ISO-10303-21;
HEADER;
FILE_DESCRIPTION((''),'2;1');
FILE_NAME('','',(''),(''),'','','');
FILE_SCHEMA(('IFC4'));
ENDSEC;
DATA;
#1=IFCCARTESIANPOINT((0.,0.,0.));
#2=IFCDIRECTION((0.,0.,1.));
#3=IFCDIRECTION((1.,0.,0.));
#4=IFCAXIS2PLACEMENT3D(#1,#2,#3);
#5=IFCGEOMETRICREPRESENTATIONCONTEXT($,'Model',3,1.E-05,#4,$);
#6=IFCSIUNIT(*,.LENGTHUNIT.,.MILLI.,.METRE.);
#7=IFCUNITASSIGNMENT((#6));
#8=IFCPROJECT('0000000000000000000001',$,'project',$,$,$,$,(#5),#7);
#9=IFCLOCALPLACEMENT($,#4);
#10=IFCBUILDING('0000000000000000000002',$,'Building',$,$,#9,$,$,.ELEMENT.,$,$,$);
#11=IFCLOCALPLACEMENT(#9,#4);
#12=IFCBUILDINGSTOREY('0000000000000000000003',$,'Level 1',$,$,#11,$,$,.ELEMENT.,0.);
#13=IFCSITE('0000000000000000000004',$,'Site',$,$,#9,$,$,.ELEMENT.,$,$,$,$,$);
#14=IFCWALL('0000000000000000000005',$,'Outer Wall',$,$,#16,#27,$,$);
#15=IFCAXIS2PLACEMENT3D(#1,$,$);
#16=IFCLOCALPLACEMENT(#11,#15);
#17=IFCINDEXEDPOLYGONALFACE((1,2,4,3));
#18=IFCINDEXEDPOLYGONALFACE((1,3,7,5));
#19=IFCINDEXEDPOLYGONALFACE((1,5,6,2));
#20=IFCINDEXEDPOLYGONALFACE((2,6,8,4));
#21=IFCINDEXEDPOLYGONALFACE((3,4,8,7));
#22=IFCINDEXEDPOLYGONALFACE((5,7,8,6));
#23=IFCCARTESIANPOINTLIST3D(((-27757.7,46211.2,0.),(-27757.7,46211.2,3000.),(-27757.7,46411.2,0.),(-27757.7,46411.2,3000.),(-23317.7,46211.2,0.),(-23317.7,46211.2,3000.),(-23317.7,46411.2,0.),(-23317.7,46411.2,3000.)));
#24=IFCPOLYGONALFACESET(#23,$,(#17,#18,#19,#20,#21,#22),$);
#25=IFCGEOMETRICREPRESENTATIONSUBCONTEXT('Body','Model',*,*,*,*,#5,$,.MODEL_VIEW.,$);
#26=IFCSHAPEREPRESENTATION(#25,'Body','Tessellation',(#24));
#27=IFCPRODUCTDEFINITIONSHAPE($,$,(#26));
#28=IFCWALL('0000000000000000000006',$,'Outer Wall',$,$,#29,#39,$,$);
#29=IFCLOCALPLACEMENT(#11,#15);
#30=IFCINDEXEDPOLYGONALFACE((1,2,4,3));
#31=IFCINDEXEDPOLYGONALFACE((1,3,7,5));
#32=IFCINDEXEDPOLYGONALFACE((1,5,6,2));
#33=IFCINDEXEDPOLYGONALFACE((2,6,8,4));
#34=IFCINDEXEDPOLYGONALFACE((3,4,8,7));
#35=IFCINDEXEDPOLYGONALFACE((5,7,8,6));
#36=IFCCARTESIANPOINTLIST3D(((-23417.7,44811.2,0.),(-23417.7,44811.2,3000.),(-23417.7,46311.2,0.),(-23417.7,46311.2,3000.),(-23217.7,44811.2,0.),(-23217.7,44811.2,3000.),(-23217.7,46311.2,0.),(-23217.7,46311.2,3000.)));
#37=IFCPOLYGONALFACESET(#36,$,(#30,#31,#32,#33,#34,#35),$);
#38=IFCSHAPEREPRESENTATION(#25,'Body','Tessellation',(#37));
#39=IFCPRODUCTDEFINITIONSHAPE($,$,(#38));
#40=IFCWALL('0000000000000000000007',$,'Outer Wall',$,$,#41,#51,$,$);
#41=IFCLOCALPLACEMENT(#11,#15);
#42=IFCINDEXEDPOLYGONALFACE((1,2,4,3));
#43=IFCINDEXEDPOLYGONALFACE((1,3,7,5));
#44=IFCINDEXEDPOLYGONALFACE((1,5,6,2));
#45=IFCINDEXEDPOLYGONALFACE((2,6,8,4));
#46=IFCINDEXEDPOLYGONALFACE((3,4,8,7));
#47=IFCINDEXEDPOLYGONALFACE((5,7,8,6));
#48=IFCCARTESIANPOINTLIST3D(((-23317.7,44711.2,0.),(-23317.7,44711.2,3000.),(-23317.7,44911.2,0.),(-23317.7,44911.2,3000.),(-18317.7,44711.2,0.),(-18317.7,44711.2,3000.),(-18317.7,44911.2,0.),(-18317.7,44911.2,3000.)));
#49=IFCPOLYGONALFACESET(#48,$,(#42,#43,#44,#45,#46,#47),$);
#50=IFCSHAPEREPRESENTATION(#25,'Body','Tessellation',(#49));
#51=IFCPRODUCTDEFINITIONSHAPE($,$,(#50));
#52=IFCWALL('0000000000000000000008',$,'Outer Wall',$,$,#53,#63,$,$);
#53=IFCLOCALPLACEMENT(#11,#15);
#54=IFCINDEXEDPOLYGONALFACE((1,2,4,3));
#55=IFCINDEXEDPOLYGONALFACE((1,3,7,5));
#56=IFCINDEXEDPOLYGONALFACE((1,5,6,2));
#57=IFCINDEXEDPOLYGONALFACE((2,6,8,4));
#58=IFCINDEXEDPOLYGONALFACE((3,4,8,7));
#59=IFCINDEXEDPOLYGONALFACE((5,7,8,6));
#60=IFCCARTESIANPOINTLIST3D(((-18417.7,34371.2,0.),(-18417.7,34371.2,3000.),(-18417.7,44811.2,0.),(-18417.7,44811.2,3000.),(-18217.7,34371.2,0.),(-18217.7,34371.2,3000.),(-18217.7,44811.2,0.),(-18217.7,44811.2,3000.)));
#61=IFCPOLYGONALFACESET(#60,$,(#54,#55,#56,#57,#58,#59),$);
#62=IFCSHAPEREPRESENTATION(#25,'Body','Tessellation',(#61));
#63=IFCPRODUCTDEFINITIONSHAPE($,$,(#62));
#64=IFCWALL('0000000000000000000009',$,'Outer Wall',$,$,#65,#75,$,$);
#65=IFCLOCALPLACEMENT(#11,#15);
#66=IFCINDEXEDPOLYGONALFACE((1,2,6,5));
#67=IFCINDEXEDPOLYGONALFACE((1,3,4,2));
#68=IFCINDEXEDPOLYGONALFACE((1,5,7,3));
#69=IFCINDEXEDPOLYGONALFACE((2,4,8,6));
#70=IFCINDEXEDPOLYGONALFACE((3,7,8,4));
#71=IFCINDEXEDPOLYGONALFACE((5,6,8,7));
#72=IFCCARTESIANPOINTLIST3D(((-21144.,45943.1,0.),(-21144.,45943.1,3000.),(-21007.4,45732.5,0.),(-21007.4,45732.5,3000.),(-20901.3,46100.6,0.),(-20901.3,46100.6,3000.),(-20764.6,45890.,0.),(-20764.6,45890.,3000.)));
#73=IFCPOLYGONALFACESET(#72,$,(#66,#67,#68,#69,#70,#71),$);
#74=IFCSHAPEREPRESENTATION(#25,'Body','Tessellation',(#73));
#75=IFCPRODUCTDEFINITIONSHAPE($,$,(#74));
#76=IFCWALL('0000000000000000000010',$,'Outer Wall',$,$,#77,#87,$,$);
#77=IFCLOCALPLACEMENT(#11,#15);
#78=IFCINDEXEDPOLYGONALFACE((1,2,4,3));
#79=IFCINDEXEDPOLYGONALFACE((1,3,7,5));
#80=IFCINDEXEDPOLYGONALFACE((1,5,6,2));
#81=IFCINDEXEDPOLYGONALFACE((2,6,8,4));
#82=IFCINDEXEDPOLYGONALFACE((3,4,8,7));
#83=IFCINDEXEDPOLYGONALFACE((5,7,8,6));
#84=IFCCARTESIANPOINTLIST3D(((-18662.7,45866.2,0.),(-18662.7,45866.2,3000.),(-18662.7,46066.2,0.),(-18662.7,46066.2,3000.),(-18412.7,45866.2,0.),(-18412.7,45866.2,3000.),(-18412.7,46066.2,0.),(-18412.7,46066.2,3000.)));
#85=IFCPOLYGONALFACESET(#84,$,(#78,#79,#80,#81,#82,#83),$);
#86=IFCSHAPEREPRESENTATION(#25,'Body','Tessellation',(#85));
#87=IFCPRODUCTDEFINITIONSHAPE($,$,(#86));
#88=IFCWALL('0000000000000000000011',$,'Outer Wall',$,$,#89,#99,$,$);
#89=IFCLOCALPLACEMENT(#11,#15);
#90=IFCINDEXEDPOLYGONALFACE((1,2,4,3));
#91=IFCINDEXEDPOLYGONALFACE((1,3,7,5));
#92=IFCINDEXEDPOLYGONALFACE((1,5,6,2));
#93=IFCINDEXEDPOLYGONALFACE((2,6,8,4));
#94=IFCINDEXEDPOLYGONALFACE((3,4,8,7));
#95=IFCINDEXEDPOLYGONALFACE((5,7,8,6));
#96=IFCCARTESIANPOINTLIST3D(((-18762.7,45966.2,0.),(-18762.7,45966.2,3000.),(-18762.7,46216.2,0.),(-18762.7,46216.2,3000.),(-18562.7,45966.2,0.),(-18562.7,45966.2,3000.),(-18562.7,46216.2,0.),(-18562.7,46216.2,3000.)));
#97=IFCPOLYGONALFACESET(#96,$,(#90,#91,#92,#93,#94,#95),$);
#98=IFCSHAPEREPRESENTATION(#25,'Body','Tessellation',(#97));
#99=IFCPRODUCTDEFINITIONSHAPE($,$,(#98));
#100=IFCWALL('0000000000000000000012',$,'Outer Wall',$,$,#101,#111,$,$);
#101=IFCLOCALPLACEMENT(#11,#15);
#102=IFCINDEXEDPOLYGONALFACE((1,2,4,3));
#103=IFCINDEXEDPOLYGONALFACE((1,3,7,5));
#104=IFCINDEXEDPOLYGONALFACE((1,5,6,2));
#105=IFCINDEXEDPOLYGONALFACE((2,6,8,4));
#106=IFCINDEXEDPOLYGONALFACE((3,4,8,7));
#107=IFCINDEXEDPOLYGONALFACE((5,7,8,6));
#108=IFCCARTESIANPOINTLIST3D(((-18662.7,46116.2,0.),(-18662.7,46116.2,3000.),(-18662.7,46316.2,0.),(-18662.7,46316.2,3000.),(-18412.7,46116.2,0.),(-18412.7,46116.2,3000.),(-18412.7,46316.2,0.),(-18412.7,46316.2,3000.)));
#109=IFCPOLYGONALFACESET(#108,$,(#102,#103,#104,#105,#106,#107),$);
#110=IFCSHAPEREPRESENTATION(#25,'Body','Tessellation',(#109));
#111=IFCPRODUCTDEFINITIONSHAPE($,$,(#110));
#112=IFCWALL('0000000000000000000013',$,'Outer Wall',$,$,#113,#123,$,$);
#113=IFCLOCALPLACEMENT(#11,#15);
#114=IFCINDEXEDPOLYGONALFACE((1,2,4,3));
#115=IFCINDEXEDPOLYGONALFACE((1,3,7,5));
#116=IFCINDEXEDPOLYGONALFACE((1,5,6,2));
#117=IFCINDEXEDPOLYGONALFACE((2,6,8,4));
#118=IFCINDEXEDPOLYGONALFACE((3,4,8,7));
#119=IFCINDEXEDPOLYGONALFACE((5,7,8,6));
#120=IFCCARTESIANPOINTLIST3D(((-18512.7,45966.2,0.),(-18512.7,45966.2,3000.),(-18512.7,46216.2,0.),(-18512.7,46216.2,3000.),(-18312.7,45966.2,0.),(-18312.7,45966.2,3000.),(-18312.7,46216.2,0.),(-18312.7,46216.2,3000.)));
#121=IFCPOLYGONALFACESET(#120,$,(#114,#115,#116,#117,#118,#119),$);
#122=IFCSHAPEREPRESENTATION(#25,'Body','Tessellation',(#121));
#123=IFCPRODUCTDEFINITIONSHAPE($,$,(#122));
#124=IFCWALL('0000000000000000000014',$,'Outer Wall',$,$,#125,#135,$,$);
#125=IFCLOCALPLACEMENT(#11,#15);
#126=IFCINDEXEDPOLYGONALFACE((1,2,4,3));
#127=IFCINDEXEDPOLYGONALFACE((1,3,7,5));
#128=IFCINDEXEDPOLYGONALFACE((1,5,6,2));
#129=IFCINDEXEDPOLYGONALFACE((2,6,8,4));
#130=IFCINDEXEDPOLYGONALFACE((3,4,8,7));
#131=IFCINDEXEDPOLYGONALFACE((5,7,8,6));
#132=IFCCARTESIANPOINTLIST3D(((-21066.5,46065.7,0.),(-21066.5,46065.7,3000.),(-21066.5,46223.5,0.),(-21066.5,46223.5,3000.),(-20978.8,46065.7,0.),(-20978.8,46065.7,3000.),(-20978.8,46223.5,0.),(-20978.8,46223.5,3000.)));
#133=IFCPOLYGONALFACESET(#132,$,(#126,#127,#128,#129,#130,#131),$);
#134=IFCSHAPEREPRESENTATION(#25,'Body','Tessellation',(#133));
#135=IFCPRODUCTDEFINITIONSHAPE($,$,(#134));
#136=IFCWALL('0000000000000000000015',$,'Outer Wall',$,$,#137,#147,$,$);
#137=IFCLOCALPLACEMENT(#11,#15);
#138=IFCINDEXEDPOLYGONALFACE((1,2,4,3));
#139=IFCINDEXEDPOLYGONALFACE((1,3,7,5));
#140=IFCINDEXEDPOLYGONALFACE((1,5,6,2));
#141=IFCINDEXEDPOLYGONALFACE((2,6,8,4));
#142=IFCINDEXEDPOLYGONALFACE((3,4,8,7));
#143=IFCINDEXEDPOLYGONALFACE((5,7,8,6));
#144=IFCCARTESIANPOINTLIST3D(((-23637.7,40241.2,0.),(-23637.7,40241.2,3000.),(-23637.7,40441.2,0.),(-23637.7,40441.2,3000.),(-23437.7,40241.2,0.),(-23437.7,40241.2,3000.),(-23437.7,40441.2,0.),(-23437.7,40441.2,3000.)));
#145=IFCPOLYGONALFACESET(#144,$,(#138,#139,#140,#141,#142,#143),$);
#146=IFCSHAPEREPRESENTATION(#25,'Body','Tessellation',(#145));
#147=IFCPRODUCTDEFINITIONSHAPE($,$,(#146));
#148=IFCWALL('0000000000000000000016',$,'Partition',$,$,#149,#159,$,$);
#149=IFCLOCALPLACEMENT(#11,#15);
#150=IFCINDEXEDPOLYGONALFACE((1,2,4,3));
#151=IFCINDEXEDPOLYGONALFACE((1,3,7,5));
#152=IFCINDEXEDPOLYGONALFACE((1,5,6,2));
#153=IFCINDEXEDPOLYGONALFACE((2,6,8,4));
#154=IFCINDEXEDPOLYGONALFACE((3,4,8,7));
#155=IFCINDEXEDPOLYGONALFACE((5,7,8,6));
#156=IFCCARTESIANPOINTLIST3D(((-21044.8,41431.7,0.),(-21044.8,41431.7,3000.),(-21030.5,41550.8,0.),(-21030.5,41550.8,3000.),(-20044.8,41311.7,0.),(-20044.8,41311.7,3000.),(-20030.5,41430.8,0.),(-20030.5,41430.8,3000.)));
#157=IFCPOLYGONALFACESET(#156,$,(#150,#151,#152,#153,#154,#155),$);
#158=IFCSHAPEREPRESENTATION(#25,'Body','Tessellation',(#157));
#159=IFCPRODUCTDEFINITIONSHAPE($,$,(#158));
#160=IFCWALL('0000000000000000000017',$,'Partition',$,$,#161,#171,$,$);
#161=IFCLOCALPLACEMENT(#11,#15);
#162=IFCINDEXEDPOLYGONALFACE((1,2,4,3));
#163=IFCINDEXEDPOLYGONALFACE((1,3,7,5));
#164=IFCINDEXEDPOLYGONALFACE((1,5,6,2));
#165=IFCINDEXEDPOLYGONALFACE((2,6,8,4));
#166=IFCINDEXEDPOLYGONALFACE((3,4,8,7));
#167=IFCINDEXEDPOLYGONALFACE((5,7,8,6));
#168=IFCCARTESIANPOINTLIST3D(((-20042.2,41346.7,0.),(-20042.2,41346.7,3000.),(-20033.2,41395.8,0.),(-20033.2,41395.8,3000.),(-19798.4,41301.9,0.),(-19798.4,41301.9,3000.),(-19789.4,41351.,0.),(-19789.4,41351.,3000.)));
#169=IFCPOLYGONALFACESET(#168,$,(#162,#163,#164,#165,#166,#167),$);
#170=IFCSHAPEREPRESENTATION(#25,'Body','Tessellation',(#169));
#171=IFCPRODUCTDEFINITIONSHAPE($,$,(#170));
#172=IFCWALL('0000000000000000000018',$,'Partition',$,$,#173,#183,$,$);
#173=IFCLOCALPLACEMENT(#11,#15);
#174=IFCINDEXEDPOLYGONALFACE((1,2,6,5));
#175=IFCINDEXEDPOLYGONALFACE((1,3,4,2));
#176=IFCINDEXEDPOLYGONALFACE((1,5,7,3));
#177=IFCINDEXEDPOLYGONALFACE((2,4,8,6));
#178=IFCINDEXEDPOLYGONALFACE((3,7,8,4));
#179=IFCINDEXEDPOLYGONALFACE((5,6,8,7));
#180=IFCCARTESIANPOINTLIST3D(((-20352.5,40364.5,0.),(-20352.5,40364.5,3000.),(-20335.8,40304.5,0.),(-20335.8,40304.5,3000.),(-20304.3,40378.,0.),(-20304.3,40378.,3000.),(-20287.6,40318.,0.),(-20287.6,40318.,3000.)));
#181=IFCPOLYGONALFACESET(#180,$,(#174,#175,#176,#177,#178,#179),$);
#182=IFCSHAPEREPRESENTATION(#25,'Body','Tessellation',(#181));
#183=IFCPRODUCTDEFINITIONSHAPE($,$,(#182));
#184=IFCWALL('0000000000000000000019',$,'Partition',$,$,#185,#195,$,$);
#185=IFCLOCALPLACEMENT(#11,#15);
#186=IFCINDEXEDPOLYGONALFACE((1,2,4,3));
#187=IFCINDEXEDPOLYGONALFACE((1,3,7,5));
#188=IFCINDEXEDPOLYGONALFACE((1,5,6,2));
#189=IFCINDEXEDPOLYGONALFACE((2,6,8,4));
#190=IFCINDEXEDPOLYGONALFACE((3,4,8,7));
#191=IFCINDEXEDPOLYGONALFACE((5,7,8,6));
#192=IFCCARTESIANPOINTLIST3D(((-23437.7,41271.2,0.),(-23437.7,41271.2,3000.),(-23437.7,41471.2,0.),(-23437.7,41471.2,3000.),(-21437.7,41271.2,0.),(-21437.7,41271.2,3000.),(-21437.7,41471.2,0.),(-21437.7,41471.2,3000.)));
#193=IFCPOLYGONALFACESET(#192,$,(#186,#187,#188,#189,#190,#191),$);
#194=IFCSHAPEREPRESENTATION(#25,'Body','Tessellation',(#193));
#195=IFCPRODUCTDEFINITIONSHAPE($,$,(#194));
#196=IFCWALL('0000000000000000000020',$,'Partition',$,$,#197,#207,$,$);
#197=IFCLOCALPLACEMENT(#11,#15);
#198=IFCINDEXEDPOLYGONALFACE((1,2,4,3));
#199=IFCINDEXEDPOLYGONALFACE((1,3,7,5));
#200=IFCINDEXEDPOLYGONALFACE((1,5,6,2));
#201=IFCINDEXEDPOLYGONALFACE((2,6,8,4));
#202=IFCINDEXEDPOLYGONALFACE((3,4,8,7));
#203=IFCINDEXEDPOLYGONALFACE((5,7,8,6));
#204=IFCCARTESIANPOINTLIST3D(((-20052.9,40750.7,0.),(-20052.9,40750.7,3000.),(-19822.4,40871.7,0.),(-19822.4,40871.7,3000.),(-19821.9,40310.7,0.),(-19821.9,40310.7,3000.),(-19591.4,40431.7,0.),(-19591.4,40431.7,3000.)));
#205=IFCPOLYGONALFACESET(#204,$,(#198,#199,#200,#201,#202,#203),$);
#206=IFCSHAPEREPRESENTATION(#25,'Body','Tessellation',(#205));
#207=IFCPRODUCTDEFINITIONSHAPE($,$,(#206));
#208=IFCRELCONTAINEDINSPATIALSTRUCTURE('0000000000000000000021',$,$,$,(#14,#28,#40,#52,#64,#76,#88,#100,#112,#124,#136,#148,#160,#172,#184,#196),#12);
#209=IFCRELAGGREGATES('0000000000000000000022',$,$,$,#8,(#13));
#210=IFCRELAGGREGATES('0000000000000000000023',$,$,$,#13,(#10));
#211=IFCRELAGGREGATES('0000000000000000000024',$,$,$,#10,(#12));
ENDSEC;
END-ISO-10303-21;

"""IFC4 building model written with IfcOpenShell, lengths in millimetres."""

from ifc_helpers import new_model, si_unit, frame, frame_2d, origin_with_axes, place, context, subcontext, project, spatial, rectangle, extrude, element, save


model = new_model("IFC4")

# Units and contexts
model_context = context("Model", 3, precision=1e-05, world=origin_with_axes())
body_context = subcontext(model_context, "Body", "Model", "MODEL_VIEW")
ifc_project = project(units=[si_unit("LENGTHUNIT", "METRE", prefix="MILLI")], contexts=[model_context])

# Site, building, storey
placement = place(None, origin_with_axes())
site = spatial("IfcSite", under=ifc_project, at=placement, Name="Site", CompositionType="ELEMENT")
building = spatial("IfcBuilding", under=site, at=placement, Name="Building", CompositionType="ELEMENT")
storey_placement = place(placement, origin_with_axes())
storey = spatial("IfcBuildingStorey", under=building, at=storey_placement, Name="Level 1", CompositionType="ELEMENT", Elevation=0.0)

# Walls
wall_1_placement = place(placement, frame((-27757.7, 46311.2, 0.0), z_axis=(0.0, 0.0, 1.0), x_axis=(1.0, 0.0, 0.0)))
element("IfcWall", 1, at=wall_1_placement, inside=storey, Name="Outer Wall", context=body_context, shape_type="SweptSolid", body=[
    extrude(rectangle(XDim=4440.0, YDim=200.0, at=frame_2d((2220.0, 0.0), x_axis=(1.0, 0.0))), origin_with_axes(), (0.0, 0.0, 1.0), 3000.0),
])
wall_2_placement = place(placement, frame((-23317.7, 46311.2, 0.0), z_axis=(0.0, 0.0, 1.0), x_axis=(0.0, -1.0, 0.0)))
element("IfcWall", 2, at=wall_2_placement, inside=storey, Name="Outer Wall", context=body_context, shape_type="SweptSolid", body=[
    extrude(rectangle(XDim=1500.0, YDim=200.0, at=frame_2d((750.0, 0.0), x_axis=(1.0, 0.0))), origin_with_axes(), (0.0, 0.0, 1.0), 3000.0),
])
wall_3_placement = place(placement, frame((-23317.7, 44811.2, 0.0), z_axis=(0.0, 0.0, 1.0), x_axis=(1.0, 0.0, 0.0)))
element("IfcWall", 3, at=wall_3_placement, inside=storey, Name="Outer Wall", context=body_context, shape_type="SweptSolid", body=[
    extrude(rectangle(XDim=5000.0, YDim=200.0, at=frame_2d((2500.0, 0.0), x_axis=(1.0, 0.0))), origin_with_axes(), (0.0, 0.0, 1.0), 3000.0),
])
wall_4_placement = place(placement, frame((-18317.7, 44811.2, 0.0), z_axis=(0.0, 0.0, 1.0), x_axis=(0.0, -1.0, 0.0)))
element("IfcWall", 4, at=wall_4_placement, inside=storey, Name="Outer Wall", context=body_context, shape_type="SweptSolid", body=[
    extrude(rectangle(XDim=10440.0, YDim=200.0, at=frame_2d((5220.0, 0.0), x_axis=(1.0, 0.0))), origin_with_axes(), (0.0, 0.0, 1.0), 3000.0),
])
wall_5_placement = place(placement, frame((-20886.0, 45811.2, 0.0), z_axis=(0.0, 0.0, 1.0), x_axis=(-0.544336, 0.838867, 0.0)))
element("IfcWall", 5, at=wall_5_placement, inside=storey, Name="Outer Wall", context=body_context, shape_type="SweptSolid", body=[
    extrude(rectangle(XDim=251.0, YDim=289.4, at=frame_2d((125.5, 0.0), x_axis=(1.0, 0.0))), origin_with_axes(), (0.0, 0.0, 1.0), 3000.0),
])
wall_6_placement = place(placement, frame((-18412.7, 45966.2, 0.0), z_axis=(0.0, 0.0, 1.0), x_axis=(-1.0, 0.0, 0.0)))
element("IfcWall", 6, at=wall_6_placement, inside=storey, Name="Outer Wall", context=body_context, shape_type="SweptSolid", body=[
    extrude(rectangle(XDim=250.0, YDim=200.0, at=frame_2d((125.0, 0.0), x_axis=(1.0, 0.0))), origin_with_axes(), (0.0, 0.0, 1.0), 3000.0),
])
wall_7_placement = place(placement, frame((-18662.7, 45966.2, 0.0), z_axis=(0.0, 0.0, 1.0), x_axis=(0.0, 1.0, 0.0)))
element("IfcWall", 7, at=wall_7_placement, inside=storey, Name="Outer Wall", context=body_context, shape_type="SweptSolid", body=[
    extrude(rectangle(XDim=250.0, YDim=200.0, at=frame_2d((125.0, 0.0), x_axis=(1.0, 0.0))), origin_with_axes(), (0.0, 0.0, 1.0), 3000.0),
])
wall_8_placement = place(placement, frame((-18662.7, 46216.2, 0.0), z_axis=(0.0, 0.0, 1.0), x_axis=(1.0, 0.0, 0.0)))
element("IfcWall", 8, at=wall_8_placement, inside=storey, Name="Outer Wall", context=body_context, shape_type="SweptSolid", body=[
    extrude(rectangle(XDim=250.0, YDim=200.0, at=frame_2d((125.0, 0.0), x_axis=(1.0, 0.0))), origin_with_axes(), (0.0, 0.0, 1.0), 3000.0),
])
wall_9_placement = place(placement, frame((-18412.7, 46216.2, 0.0), z_axis=(0.0, 0.0, 1.0), x_axis=(0.0, -1.0, 0.0)))
element("IfcWall", 9, at=wall_9_placement, inside=storey, Name="Outer Wall", context=body_context, shape_type="SweptSolid", body=[
    extrude(rectangle(XDim=250.0, YDim=200.0, at=frame_2d((125.0, 0.0), x_axis=(1.0, 0.0))), origin_with_axes(), (0.0, 0.0, 1.0), 3000.0),
])
wall_10_placement = place(placement, frame((-21022.7, 46065.7, 0.0), z_axis=(0.0, 0.0, 1.0), x_axis=(0.0, 1.0, 0.0)))
element("IfcWall", 10, at=wall_10_placement, inside=storey, Name="Outer Wall", context=body_context, shape_type="SweptSolid", body=[
    extrude(rectangle(XDim=157.8, YDim=87.8, at=frame_2d((78.9, 0.0), x_axis=(1.0, 0.0))), origin_with_axes(), (0.0, 0.0, 1.0), 3000.0),
])
wall_11_placement = place(placement, frame((-23437.7, 40341.2, 0.0), z_axis=(0.0, 0.0, 1.0), x_axis=(-1.0, 0.0, 0.0)))
element("IfcWall", 11, at=wall_11_placement, inside=storey, Name="Outer Wall", context=body_context, shape_type="SweptSolid", body=[
    extrude(rectangle(XDim=200.0, YDim=200.0, at=frame_2d((100.0, 0.0), x_axis=(1.0, 0.0))), origin_with_axes(), (0.0, 0.0, 1.0), 3000.0),
])
wall_12_placement = place(placement, frame((-21037.7, 41491.2, 0.0), z_axis=(0.0, 0.0, 1.0), x_axis=(0.992877, -0.119145, 0.0)))
element("IfcWall", 12, at=wall_12_placement, inside=storey, Name="Partition", context=body_context, shape_type="SweptSolid", body=[
    extrude(rectangle(XDim=1007.2, YDim=120.0, at=frame_2d((503.6, 0.0), x_axis=(1.0, 0.0))), origin_with_axes(), (0.0, 0.0, 1.0), 3000.0),
])
wall_13_placement = place(placement, frame((-20037.7, 41371.2, 0.0), z_axis=(0.0, 0.0, 1.0), x_axis=(0.983539, -0.180698, 0.0)))
element("IfcWall", 13, at=wall_13_placement, inside=storey, Name="Partition", context=body_context, shape_type="SweptSolid", body=[
    extrude(rectangle(XDim=247.8, YDim=50.0, at=frame_2d((123.9, 0.0), x_axis=(1.0, 0.0))), origin_with_axes(), (0.0, 0.0, 1.0), 3000.0),
])
wall_14_placement = place(placement, frame((-20328.4, 40371.2, 0.0), z_axis=(0.0, 0.0, 1.0), x_axis=(0.268447, -0.963294, 0.0)))
element("IfcWall", 14, at=wall_14_placement, inside=storey, Name="Partition", context=body_context, shape_type="SweptSolid", body=[
    extrude(rectangle(XDim=62.3, YDim=50.0, at=frame_2d((31.1, 0.0), x_axis=(1.0, 0.0))), origin_with_axes(), (0.0, 0.0, 1.0), 3000.0),
])
wall_15_placement = place(placement, frame((-21437.7, 41371.2, 0.0), z_axis=(0.0, 0.0, 1.0), x_axis=(-1.0, 0.0, 0.0)))
element("IfcWall", 15, at=wall_15_placement, inside=storey, Name="Partition", context=body_context, shape_type="SweptSolid", body=[
    extrude(rectangle(XDim=2000.0, YDim=200.0, at=frame_2d((1000.0, 0.0), x_axis=(1.0, 0.0))), origin_with_axes(), (0.0, 0.0, 1.0), 3000.0),
])
wall_16_placement = place(placement, frame((-19706.7, 40371.2, 0.0), z_axis=(0.0, 0.0, 1.0), x_axis=(-0.464838, 0.885396, 0.0)))
element("IfcWall", 16, at=wall_16_placement, inside=storey, Name="Partition", context=body_context, shape_type="SweptSolid", body=[
    extrude(rectangle(XDim=497.0, YDim=260.3, at=frame_2d((248.5, 0.0), x_axis=(1.0, 0.0))), origin_with_axes(), (0.0, 0.0, 1.0), 3000.0),
])

save(model, "model.ifc")
